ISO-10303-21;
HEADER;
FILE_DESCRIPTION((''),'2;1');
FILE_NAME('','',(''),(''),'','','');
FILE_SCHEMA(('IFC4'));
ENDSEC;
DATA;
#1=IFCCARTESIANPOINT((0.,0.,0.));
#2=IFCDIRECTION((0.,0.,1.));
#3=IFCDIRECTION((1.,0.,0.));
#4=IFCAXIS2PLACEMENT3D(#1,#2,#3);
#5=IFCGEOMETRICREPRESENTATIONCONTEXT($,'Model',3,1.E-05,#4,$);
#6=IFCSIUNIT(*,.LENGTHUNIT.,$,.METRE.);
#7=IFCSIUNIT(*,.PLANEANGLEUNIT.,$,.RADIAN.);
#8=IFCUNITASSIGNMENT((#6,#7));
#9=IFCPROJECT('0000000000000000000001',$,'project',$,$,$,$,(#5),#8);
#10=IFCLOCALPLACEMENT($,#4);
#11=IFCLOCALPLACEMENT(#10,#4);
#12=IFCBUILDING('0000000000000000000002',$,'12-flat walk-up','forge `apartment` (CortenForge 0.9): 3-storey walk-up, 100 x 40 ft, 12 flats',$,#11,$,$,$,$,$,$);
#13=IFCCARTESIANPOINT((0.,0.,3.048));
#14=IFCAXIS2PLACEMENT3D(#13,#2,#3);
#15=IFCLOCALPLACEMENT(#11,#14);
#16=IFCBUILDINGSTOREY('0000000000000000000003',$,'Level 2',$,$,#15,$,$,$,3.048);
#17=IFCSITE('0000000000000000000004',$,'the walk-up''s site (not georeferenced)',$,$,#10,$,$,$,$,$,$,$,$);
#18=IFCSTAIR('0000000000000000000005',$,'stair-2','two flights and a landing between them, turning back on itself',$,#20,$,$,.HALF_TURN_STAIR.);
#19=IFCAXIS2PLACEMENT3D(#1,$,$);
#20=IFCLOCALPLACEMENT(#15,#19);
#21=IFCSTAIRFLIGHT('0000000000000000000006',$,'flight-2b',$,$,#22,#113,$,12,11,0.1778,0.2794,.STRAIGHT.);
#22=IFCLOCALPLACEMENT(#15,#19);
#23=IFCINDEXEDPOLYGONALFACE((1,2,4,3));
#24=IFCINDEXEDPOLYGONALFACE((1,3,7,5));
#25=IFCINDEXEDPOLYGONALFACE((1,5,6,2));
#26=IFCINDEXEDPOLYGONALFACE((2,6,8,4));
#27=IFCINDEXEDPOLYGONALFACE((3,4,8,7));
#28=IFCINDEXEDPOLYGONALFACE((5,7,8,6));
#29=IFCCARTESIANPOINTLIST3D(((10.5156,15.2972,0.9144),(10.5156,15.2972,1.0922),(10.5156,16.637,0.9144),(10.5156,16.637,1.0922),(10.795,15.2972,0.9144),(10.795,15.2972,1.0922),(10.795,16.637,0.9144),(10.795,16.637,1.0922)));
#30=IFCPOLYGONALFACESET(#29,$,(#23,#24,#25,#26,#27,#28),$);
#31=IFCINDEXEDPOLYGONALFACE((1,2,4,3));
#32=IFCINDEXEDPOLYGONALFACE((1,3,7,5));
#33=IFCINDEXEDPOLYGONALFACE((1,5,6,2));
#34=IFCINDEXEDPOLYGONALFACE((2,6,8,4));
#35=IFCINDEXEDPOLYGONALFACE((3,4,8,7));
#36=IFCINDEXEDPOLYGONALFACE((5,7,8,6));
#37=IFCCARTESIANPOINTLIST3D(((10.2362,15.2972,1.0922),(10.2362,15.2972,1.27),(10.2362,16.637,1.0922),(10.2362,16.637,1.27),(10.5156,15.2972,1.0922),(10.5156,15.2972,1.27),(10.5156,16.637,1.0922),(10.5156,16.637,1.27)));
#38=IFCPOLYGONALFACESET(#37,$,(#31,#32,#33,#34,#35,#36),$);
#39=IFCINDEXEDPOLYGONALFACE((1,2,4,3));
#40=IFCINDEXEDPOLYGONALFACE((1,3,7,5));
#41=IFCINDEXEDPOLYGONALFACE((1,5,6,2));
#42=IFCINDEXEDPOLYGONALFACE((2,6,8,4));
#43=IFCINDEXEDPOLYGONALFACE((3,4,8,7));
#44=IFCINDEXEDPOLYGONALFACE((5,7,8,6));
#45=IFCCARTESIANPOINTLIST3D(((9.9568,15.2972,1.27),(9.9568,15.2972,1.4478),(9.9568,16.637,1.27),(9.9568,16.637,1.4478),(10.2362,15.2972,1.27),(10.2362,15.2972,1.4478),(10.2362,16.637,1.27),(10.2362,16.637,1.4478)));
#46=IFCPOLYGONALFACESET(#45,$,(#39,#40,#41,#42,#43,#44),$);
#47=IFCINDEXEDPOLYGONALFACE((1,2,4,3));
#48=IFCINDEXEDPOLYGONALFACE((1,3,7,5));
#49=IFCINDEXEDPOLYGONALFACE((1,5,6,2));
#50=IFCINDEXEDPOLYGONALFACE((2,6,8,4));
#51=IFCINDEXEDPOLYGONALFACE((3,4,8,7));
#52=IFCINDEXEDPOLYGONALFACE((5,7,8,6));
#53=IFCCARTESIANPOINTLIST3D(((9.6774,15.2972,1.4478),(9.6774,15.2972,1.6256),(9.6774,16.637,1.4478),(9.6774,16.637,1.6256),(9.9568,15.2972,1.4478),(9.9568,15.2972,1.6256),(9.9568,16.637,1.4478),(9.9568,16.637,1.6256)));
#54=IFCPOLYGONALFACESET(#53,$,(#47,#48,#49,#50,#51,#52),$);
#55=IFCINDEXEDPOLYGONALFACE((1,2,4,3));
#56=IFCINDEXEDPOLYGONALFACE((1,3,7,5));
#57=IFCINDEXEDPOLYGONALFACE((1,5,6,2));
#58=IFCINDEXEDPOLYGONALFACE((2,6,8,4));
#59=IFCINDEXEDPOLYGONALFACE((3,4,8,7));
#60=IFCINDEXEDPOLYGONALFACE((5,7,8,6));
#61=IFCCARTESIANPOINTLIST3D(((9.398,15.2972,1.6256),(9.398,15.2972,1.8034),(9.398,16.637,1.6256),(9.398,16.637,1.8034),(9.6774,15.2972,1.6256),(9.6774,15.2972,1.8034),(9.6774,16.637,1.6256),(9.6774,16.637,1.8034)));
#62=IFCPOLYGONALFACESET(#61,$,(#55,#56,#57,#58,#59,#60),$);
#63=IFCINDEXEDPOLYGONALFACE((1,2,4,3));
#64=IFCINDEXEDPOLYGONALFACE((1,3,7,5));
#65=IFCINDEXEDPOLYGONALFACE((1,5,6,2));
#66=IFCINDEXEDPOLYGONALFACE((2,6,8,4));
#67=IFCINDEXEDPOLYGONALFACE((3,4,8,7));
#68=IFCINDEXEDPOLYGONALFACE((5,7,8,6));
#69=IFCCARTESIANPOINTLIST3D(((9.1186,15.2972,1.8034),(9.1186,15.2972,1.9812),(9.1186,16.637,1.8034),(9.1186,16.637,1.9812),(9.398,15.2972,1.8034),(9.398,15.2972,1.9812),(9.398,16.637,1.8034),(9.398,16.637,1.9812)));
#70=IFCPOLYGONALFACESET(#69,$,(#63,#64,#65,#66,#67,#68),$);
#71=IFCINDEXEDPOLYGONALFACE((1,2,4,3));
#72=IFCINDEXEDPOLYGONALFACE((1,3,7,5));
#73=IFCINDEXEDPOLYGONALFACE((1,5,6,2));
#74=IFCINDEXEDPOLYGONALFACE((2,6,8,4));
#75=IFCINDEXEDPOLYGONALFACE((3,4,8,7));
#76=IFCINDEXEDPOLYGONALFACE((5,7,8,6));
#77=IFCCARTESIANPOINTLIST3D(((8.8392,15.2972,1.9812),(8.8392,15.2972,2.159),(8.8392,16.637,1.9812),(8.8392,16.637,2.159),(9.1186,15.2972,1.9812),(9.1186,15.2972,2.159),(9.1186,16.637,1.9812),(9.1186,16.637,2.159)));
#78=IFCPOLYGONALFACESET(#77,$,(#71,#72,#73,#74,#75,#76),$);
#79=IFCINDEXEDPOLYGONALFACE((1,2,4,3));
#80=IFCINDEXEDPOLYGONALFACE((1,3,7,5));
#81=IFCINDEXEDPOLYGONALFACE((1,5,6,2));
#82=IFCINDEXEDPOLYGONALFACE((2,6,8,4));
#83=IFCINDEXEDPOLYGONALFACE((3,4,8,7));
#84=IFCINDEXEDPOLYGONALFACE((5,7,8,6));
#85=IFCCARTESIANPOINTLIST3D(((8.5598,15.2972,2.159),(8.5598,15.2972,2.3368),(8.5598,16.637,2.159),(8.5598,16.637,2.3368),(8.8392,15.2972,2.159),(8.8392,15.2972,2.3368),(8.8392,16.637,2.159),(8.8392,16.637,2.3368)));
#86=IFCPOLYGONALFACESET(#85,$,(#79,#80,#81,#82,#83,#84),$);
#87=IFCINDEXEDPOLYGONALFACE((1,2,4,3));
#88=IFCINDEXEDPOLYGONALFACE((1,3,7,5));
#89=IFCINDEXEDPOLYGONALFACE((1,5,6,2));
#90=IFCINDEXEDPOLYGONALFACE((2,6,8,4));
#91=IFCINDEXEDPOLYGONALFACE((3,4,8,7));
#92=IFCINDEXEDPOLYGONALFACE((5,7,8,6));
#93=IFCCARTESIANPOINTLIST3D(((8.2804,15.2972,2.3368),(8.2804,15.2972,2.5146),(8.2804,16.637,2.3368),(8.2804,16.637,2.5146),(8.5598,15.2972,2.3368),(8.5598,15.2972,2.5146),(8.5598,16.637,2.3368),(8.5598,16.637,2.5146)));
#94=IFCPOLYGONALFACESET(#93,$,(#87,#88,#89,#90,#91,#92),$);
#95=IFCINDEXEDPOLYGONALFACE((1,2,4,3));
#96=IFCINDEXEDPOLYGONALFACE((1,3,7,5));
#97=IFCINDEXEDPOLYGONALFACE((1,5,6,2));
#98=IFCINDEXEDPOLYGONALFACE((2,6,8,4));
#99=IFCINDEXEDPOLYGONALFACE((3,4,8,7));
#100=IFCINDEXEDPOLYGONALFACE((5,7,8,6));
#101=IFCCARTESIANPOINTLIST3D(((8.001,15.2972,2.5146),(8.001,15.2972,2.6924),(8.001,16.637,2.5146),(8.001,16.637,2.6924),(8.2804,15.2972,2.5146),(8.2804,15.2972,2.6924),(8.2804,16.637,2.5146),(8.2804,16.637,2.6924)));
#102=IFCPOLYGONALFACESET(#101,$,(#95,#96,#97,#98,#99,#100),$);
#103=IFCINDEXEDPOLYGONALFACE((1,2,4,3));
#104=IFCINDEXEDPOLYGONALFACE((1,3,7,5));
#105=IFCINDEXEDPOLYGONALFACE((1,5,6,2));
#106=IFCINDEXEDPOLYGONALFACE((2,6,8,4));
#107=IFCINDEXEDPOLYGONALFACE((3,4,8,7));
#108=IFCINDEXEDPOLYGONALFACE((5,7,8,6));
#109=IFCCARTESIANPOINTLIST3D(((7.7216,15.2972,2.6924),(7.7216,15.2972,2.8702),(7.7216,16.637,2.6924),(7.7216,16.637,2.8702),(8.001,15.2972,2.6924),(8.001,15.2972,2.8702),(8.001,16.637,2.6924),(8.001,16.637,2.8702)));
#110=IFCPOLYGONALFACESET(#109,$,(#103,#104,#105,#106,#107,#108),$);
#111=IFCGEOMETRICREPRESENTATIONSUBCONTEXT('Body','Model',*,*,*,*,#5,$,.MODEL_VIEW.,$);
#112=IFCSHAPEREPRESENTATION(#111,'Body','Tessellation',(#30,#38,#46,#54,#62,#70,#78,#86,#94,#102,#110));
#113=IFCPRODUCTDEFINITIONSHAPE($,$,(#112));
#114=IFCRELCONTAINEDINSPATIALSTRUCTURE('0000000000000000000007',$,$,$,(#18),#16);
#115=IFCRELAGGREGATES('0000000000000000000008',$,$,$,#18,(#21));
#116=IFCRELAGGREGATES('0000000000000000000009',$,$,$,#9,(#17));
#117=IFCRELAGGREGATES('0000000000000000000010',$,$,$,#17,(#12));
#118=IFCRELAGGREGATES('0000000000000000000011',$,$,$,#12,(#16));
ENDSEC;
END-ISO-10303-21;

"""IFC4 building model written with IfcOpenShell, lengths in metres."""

from ifc_helpers import new_model, si_unit, frame, frame_2d, origin_with_axes, place, context, subcontext, project, spatial, rectangle, extrude, element, aggregate, save


model = new_model("IFC4")

# Units and contexts
model_context = context("Model", 3, precision=1e-05, world=origin_with_axes())
body_context = subcontext(model_context, "Body", "Model", "MODEL_VIEW")
ifc_project = project(units=[si_unit("LENGTHUNIT", "METRE"), si_unit("PLANEANGLEUNIT", "RADIAN")], contexts=[model_context])

# Site, building, storey
site_placement = place(None, origin_with_axes())
site = spatial("IfcSite", under=ifc_project, at=site_placement, Name="the walk-up's site (not georeferenced)")
building_placement = place(site_placement, origin_with_axes())
building = spatial("IfcBuilding", under=site, at=building_placement, Name="12-flat walk-up", Description="forge `apartment` (CortenForge 0.9): 3-storey walk-up, 100 x 40 ft, 12 flats")
storey_placement = place(building_placement, frame((0.0, 0.0, 3.048), z_axis=(0.0, 0.0, 1.0), x_axis=(1.0, 0.0, 0.0)))
storey = spatial("IfcBuildingStorey", under=building, at=storey_placement, Name="Level 2", Elevation=3.048)

# Stair, stair flight
stair_placement = place(storey_placement, frame((0.0, 0.0, -3.048), z_axis=(0.0, 0.0, 1.0), x_axis=(1.0, 0.0, 0.0)))
stair = element("IfcStair", 1, at=stair_placement, inside=storey, Name="stair-2", Description="two flights and a landing between them, turning back on itself", PredefinedType="HALF_TURN_STAIR")
stair_flight_placement = place(stair_placement, frame((7.7216, 15.2972, 3.9624), z_axis=(0.0, 0.0, 1.0), x_axis=(1.0, 0.0, 0.0)))
stair_flight = element("IfcStairFlight", 2, at=stair_flight_placement, Name="flight-2b", NumberOfRisers=12, NumberOfTreads=11, PredefinedType="STRAIGHT", RiserHeight=0.1778, TreadLength=0.2794, context=body_context, shape_type="SweptSolid", body=[
    extrude(rectangle(XDim=0.2794, YDim=1.3399, at=frame_2d((0.1397, 0.6699))), frame((2.794, 0.0, 0.0)), (0.0, 0.0, 1.0), 0.1778),
    extrude(rectangle(XDim=0.2794, YDim=1.3399, at=frame_2d((0.1397, 0.6699))), frame((2.5146, 0.0, 0.1778)), (0.0, 0.0, 1.0), 0.1778),
    extrude(rectangle(XDim=0.2794, YDim=1.3399, at=frame_2d((0.1397, 0.6699))), frame((2.2352, 0.0, 0.3556)), (0.0, 0.0, 1.0), 0.1778),
    extrude(rectangle(XDim=0.2794, YDim=1.3399, at=frame_2d((0.1397, 0.6699))), frame((1.9558, 0.0, 0.5334)), (0.0, 0.0, 1.0), 0.1778),
    extrude(rectangle(XDim=0.2794, YDim=1.3399, at=frame_2d((0.1397, 0.6699))), frame((1.6764, 0.0, 0.7112)), (0.0, 0.0, 1.0), 0.1778),
    extrude(rectangle(XDim=0.2794, YDim=1.3399, at=frame_2d((0.1397, 0.6699))), frame((1.397, 0.0, 0.889)), (0.0, 0.0, 1.0), 0.1778),
    extrude(rectangle(XDim=0.2794, YDim=1.3399, at=frame_2d((0.1397, 0.6699))), frame((1.1176, 0.0, 1.0668)), (0.0, 0.0, 1.0), 0.1778),
    extrude(rectangle(XDim=0.2794, YDim=1.3399, at=frame_2d((0.1397, 0.6699))), frame((0.8382, 0.0, 1.2446)), (0.0, 0.0, 1.0), 0.1778),
    extrude(rectangle(XDim=0.2794, YDim=1.3399, at=frame_2d((0.1397, 0.6699))), frame((0.5588, 0.0, 1.4224)), (0.0, 0.0, 1.0), 0.1778),
    extrude(rectangle(XDim=0.2794, YDim=1.3399, at=frame_2d((0.1397, 0.6699))), frame((0.2794, 0.0, 1.6002)), (0.0, 0.0, 1.0), 0.1778),
    extrude(rectangle(XDim=0.2794, YDim=1.3399, at=frame_2d((0.1397, 0.6699))), frame((0.0, 0.0, 1.778)), (0.0, 0.0, 1.0), 0.1778),
])
aggregate(stair, [stair_flight])

save(model, "model.ifc")
